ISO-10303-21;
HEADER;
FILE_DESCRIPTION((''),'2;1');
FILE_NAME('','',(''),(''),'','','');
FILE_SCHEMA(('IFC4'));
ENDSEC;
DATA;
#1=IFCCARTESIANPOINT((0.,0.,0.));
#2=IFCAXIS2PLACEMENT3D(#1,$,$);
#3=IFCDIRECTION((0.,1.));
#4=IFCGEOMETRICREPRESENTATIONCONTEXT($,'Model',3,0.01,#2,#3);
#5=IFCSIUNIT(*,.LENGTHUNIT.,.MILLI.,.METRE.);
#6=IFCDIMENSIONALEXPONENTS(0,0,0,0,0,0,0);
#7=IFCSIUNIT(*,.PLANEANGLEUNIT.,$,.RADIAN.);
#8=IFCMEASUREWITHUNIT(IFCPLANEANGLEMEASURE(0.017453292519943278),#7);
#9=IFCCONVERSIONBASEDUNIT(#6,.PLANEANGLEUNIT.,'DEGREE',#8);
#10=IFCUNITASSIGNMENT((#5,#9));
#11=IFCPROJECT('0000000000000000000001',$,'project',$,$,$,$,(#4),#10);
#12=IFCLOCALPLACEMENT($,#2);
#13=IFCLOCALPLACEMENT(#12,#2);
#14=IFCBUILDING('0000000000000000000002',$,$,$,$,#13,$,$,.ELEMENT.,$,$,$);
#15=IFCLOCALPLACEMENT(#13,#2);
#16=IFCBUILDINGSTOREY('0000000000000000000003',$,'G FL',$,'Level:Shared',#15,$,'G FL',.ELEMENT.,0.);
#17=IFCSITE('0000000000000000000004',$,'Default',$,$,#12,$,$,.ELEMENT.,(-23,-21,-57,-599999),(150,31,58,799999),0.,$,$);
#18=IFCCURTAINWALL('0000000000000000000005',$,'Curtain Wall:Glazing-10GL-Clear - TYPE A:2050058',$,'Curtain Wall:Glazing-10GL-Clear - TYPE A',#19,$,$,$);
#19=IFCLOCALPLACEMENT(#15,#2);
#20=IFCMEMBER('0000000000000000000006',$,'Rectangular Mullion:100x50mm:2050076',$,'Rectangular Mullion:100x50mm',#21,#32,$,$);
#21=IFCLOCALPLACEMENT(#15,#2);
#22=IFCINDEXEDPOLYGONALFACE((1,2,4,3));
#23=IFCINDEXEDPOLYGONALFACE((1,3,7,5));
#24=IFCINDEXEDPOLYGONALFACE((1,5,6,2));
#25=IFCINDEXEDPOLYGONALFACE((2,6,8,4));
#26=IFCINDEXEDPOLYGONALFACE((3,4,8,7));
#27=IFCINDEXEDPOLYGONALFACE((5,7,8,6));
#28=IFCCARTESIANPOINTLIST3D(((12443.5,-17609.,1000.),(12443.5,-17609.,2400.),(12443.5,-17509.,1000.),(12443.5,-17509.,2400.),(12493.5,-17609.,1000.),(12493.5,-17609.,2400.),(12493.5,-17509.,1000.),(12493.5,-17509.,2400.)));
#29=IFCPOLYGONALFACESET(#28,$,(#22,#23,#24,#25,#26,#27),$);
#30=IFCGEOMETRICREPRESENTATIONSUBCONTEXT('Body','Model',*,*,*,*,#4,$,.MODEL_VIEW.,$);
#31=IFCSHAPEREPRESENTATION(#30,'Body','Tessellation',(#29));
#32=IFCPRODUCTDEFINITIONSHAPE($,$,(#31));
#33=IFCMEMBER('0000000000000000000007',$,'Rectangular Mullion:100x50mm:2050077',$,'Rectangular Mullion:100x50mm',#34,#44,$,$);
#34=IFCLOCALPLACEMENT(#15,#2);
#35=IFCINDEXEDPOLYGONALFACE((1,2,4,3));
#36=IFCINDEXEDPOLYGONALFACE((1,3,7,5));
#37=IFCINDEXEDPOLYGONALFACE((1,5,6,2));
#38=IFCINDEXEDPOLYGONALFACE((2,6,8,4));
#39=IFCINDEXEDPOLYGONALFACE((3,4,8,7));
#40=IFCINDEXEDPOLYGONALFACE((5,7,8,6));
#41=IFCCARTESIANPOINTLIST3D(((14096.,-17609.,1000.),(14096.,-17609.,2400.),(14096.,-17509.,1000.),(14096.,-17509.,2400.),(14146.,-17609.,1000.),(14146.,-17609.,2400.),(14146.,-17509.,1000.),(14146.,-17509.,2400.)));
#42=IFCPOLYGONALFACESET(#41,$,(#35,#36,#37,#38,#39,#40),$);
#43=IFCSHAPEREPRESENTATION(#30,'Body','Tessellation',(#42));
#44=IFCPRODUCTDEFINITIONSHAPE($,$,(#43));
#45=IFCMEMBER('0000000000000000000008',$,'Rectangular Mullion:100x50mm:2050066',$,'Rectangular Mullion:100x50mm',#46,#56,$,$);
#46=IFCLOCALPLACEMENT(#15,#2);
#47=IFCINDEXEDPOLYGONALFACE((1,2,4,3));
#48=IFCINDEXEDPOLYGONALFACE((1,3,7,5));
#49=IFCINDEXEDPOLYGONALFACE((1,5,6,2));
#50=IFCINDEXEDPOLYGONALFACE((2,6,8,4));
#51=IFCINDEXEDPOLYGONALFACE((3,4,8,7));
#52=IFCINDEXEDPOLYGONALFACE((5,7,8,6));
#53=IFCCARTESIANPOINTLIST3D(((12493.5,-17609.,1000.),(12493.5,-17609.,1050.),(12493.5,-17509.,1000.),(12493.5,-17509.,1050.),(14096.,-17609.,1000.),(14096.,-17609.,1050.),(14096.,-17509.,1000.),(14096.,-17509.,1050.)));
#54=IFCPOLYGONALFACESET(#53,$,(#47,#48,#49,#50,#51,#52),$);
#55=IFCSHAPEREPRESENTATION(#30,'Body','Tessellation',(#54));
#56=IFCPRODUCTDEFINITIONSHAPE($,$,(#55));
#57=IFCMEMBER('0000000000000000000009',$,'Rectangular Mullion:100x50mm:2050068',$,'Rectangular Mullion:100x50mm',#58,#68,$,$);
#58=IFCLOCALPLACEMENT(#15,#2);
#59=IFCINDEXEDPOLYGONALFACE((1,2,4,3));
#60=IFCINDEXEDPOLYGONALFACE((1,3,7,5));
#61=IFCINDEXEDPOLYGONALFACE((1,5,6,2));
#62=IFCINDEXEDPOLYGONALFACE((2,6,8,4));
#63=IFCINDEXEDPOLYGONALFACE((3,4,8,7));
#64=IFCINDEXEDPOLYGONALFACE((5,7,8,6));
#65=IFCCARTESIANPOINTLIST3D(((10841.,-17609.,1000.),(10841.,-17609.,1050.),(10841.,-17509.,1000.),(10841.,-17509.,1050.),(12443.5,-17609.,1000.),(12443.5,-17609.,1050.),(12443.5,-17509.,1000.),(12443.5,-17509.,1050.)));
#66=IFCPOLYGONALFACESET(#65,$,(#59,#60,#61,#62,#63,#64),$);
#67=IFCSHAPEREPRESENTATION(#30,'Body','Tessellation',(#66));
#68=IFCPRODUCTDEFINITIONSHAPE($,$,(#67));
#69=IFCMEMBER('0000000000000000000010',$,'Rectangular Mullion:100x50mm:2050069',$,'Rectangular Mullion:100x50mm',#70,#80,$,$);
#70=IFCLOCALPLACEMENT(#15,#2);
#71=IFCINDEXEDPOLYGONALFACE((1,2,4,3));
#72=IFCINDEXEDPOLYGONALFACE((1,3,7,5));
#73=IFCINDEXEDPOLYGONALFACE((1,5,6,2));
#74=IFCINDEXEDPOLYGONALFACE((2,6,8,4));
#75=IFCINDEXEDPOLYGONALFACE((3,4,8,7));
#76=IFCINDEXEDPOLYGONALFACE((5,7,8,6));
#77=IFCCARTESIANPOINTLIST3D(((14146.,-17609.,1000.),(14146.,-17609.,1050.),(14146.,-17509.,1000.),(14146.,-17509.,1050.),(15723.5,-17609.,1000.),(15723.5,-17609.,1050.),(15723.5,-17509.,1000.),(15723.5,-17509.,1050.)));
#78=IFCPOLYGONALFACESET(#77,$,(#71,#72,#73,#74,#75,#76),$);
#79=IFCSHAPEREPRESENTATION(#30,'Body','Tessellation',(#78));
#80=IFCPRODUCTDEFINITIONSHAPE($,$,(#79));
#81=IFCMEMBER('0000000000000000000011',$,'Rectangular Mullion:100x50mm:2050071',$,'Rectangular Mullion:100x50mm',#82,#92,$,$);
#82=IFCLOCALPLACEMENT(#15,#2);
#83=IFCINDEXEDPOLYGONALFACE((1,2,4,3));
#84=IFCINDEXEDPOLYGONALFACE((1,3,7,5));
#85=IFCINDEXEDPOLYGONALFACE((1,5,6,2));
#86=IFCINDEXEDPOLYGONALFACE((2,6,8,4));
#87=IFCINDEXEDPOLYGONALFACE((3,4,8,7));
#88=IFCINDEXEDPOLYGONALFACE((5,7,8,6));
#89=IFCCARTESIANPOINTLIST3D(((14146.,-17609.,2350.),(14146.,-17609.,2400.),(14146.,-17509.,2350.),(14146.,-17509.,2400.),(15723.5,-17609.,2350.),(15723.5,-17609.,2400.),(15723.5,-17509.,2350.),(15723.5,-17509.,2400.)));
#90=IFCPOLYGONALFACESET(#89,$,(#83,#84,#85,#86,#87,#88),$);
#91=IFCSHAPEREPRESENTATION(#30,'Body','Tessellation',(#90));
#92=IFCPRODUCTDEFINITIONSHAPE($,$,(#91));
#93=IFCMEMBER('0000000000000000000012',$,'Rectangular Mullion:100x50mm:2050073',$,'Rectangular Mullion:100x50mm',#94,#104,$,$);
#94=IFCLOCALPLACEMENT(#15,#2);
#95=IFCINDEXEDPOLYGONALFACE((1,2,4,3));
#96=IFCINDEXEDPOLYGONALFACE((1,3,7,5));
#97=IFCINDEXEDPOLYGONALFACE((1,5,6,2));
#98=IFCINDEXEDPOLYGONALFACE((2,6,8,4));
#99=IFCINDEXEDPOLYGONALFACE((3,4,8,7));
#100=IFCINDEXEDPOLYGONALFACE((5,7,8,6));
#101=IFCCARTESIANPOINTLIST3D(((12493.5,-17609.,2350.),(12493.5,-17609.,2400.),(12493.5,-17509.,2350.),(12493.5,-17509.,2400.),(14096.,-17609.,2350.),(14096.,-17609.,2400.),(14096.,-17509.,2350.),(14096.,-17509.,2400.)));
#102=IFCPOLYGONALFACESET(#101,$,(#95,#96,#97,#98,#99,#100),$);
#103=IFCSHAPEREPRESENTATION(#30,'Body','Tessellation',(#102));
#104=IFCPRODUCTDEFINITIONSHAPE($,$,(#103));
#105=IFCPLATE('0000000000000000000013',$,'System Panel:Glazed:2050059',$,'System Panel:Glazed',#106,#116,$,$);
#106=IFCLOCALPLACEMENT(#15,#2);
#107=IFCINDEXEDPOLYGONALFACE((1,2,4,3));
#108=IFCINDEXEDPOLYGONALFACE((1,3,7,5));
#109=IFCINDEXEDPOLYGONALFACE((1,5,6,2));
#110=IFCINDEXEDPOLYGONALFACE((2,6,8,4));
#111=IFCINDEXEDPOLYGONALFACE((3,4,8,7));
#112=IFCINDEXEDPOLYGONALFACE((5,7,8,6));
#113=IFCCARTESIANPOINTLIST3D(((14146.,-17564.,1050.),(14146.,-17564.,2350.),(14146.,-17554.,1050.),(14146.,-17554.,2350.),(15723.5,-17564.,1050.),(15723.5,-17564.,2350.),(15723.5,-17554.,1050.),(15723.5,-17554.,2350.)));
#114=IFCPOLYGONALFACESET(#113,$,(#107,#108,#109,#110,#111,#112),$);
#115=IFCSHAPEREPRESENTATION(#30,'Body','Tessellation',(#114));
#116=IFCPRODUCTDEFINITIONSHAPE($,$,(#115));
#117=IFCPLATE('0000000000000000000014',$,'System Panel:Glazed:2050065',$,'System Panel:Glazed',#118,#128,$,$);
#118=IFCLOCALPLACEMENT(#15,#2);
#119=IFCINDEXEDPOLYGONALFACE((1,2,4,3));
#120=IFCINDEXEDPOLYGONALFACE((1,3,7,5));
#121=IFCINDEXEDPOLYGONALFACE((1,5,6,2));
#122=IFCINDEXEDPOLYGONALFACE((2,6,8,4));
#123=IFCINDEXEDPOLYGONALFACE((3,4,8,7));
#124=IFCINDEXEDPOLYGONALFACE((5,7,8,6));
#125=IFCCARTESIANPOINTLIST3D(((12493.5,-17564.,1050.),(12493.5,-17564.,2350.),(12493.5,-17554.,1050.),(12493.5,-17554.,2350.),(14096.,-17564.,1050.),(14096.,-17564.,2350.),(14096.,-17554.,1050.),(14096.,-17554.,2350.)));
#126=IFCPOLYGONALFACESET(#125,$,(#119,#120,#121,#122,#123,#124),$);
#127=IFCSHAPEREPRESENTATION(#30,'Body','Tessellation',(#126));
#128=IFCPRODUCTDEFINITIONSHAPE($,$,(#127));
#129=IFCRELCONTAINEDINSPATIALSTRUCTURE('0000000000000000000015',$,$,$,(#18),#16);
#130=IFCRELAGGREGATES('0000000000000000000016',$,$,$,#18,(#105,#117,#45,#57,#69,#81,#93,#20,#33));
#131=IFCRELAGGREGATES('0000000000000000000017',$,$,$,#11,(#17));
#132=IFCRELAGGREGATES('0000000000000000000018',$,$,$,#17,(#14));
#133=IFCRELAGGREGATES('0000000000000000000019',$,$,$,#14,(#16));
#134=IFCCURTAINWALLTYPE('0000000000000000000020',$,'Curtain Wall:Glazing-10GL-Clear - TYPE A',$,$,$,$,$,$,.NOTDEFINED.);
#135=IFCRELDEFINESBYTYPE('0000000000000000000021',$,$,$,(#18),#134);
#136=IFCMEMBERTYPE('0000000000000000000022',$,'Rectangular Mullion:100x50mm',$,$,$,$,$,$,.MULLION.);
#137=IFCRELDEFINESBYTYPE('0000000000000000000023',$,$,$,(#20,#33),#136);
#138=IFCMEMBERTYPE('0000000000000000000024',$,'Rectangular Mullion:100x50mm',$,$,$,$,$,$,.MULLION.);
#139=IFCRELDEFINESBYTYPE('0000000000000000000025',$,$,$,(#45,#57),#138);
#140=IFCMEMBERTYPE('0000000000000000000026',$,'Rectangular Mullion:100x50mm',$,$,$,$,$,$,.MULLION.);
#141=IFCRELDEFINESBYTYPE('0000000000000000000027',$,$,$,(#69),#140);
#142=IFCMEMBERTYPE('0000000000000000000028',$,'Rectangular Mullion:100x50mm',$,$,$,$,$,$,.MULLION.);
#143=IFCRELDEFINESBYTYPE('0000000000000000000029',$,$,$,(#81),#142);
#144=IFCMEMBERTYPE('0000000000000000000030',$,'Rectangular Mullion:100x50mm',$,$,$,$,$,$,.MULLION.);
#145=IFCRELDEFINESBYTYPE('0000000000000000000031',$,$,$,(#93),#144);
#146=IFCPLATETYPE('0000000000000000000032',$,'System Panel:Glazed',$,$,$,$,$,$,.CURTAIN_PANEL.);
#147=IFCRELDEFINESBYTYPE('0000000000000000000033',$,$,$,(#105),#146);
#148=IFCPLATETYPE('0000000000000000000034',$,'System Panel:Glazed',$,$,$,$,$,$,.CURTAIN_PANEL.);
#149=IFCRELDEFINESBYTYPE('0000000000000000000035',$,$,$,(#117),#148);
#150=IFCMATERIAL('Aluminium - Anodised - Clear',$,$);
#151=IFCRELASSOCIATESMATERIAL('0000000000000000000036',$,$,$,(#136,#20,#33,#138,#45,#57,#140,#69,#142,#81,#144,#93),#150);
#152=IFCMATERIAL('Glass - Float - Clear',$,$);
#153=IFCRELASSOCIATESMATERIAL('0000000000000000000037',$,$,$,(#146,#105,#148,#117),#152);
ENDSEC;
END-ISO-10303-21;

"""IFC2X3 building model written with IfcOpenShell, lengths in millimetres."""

from ifc_helpers import new_model, entity, si_unit, converted_unit, direction, frame, frame_2d, origin, origin_2d_with_axis, place, context, subcontext, project, spatial, rectangle, extrude, source, transform, mapped, material, type_object, type_shapes, element, aggregate, save


model = new_model("IFC2X3")

# Units and contexts
model_context = context("Model", 3, precision=0.01, world=origin(), true_north=direction((0.0, 1.0)))
body_context = subcontext(model_context, "Body", "Model", "MODEL_VIEW")
ifc_project = project(units=[si_unit("LENGTHUNIT", "METRE", prefix="MILLI"), converted_unit("PLANEANGLEUNIT", "DEGREE", entity("IfcPlaneAngleMeasure", 0.017453292519943278), si_unit("PLANEANGLEUNIT", "RADIAN"), dimensions=[0, 0, 0, 0, 0, 0, 0])], contexts=[model_context])

# Site, building, storey
site_placement = place(None, origin())
site = spatial("IfcSite", under=ifc_project, at=site_placement, Name="Default", CompositionType="ELEMENT", RefLatitude=(-23, -21, -57, -599999), RefLongitude=(150, 31, 58, 799999), RefElevation=0.0)
building_placement = place(site_placement, origin())
building = spatial("IfcBuilding", under=site, at=building_placement, CompositionType="ELEMENT")
storey_placement = place(building_placement, origin())
storey = spatial("IfcBuildingStorey", under=building, at=storey_placement, Name="G FL", ObjectType="Level:Shared", LongName="G FL", CompositionType="ELEMENT", Elevation=0.0)

# Curtain wall, members, plates
curtain_wall_type = type_object("IfcCurtainWallType", Name="Curtain Wall:Glazing-10GL-Clear - TYPE A", PredefinedType="NOTDEFINED")
curtain_wall_placement = place(storey_placement, origin())
curtain_wall = element("IfcCurtainWall", 1, at=curtain_wall_placement, inside=storey, type_object=curtain_wall_type, Name="Curtain Wall:Glazing-10GL-Clear - TYPE A:2050058", ObjectType="Curtain Wall:Glazing-10GL-Clear - TYPE A")
ifc_material_1 = material(Name="Aluminium - Anodised - Clear")
member_type_1 = type_object("IfcMemberType", Name="Rectangular Mullion:100x50mm", PredefinedType="MULLION", material=ifc_material_1)
shared_shape_1 = source(origin(), body_context, "Body", "SweptSolid", [
    extrude(rectangle(XDim=50.0, YDim=100.0, at=frame_2d((0.0, 0.0), x_axis=(1.0, 0.0))), frame((0.0, 0.0, -1400.0), z_axis=(0.0, 0.0, 1.0), x_axis=(-1.0, 0.0, 0.0)), (0.0, 0.0, 1.0), 1400.0),
])
type_shapes(member_type_1, [shared_shape_1])
member_1_placement = place(curtain_wall_placement, frame((12468.5, -17559.0, 1000.0), z_axis=(0.0, 0.0, -1.0), x_axis=(-1.0, 0.0, 0.0)))
member_1 = element("IfcMember", 2, at=member_1_placement, type_object=member_type_1, material=ifc_material_1, Name="Rectangular Mullion:100x50mm:2050076", ObjectType="Rectangular Mullion:100x50mm", context=body_context, shape_type="MappedRepresentation", body=[
    mapped(shared_shape_1, transform((0.0, 0.0, 0.0), scale=1.0)),
])
member_2_placement = place(curtain_wall_placement, frame((14121.0, -17559.0, 1000.0), z_axis=(0.0, 0.0, -1.0), x_axis=(-1.0, 0.0, 0.0)))
member_2 = element("IfcMember", 3, at=member_2_placement, type_object=member_type_1, material=ifc_material_1, Name="Rectangular Mullion:100x50mm:2050077", ObjectType="Rectangular Mullion:100x50mm", context=body_context, shape_type="MappedRepresentation", body=[
    mapped(shared_shape_1, transform((0.0, 0.0, 0.0), scale=1.0)),
])
member_type_2 = type_object("IfcMemberType", Name="Rectangular Mullion:100x50mm", PredefinedType="MULLION", material=ifc_material_1)
shared_shape_2 = source(origin(), body_context, "Body", "SweptSolid", [
    extrude(rectangle(XDim=50.0, YDim=100.0, at=frame_2d((0.0, 0.0), x_axis=(1.0, 0.0))), frame((-25.0, 0.0, -1602.5), z_axis=(0.0, 0.0, 1.0), x_axis=(-1.0, 0.0, 0.0)), (0.0, 0.0, 1.0), 1602.5),
])
type_shapes(member_type_2, [shared_shape_2])
member_3_placement = place(curtain_wall_placement, frame((14096.0, -17559.0, 1000.0), z_axis=(1.0, 0.0, 0.0), x_axis=(0.0, 0.0, -1.0)))
member_3 = element("IfcMember", 4, at=member_3_placement, type_object=member_type_2, material=ifc_material_1, Name="Rectangular Mullion:100x50mm:2050066", ObjectType="Rectangular Mullion:100x50mm", context=body_context, shape_type="MappedRepresentation", body=[
    mapped(shared_shape_2, transform((0.0, 0.0, 0.0), scale=1.0)),
])
member_4_placement = place(curtain_wall_placement, frame((12443.5, -17559.0, 1000.0), z_axis=(1.0, 0.0, 0.0), x_axis=(0.0, 0.0, -1.0)))
member_4 = element("IfcMember", 5, at=member_4_placement, type_object=member_type_2, material=ifc_material_1, Name="Rectangular Mullion:100x50mm:2050068", ObjectType="Rectangular Mullion:100x50mm", context=body_context, shape_type="MappedRepresentation", body=[
    mapped(shared_shape_2, transform((0.0, 0.0, 0.0), scale=1.0)),
])
member_type_3 = type_object("IfcMemberType", Name="Rectangular Mullion:100x50mm", PredefinedType="MULLION", material=ifc_material_1)
shared_shape_3 = source(origin(), body_context, "Body", "SweptSolid", [
    extrude(rectangle(XDim=50.0, YDim=100.0, at=frame_2d((0.0, 0.0), x_axis=(1.0, 0.0))), frame((-25.0, 0.0, -1577.5), z_axis=(0.0, 0.0, 1.0), x_axis=(-1.0, 0.0, 0.0)), (0.0, 0.0, 1.0), 1577.5),
])
type_shapes(member_type_3, [shared_shape_3])
member_5_placement = place(curtain_wall_placement, frame((15723.5, -17559.0, 1000.0), z_axis=(1.0, 0.0, 0.0), x_axis=(0.0, 0.0, -1.0)))
member_5 = element("IfcMember", 6, at=member_5_placement, type_object=member_type_3, material=ifc_material_1, Name="Rectangular Mullion:100x50mm:2050069", ObjectType="Rectangular Mullion:100x50mm", context=body_context, shape_type="MappedRepresentation", body=[
    mapped(shared_shape_3, transform((0.0, 0.0, 0.0), scale=1.0)),
])
member_type_4 = type_object("IfcMemberType", Name="Rectangular Mullion:100x50mm", PredefinedType="MULLION", material=ifc_material_1)
shared_shape_4 = source(origin(), body_context, "Body", "SweptSolid", [
    extrude(rectangle(XDim=50.0, YDim=100.0, at=origin_2d_with_axis()), frame((-25.0, 0.0, -1577.5), z_axis=(0.0, 0.0, 1.0), x_axis=(-1.0, 0.0, 0.0)), (0.0, 0.0, 1.0), 1577.5),
])
type_shapes(member_type_4, [shared_shape_4])
member_6_placement = place(curtain_wall_placement, frame((14146.0, -17559.0, 2400.0), z_axis=(-1.0, 0.0, 0.0), x_axis=(0.0, 0.0, 1.0)))
member_6 = element("IfcMember", 7, at=member_6_placement, type_object=member_type_4, material=ifc_material_1, Name="Rectangular Mullion:100x50mm:2050071", ObjectType="Rectangular Mullion:100x50mm", context=body_context, shape_type="MappedRepresentation", body=[
    mapped(shared_shape_4, transform((0.0, 0.0, 0.0), scale=1.0)),
])
member_type_5 = type_object("IfcMemberType", Name="Rectangular Mullion:100x50mm", PredefinedType="MULLION", material=ifc_material_1)
shared_shape_5 = source(origin(), body_context, "Body", "SweptSolid", [
    extrude(rectangle(XDim=50.0, YDim=100.0, at=origin_2d_with_axis()), frame((-25.0, 0.0, -1602.5), z_axis=(0.0, 0.0, 1.0), x_axis=(-1.0, 0.0, 0.0)), (0.0, 0.0, 1.0), 1602.5),
])
type_shapes(member_type_5, [shared_shape_5])
member_7_placement = place(curtain_wall_placement, frame((12493.5, -17559.0, 2400.0), z_axis=(-1.0, 0.0, 0.0), x_axis=(0.0, 0.0, 1.0)))
member_7 = element("IfcMember", 8, at=member_7_placement, type_object=member_type_5, material=ifc_material_1, Name="Rectangular Mullion:100x50mm:2050073", ObjectType="Rectangular Mullion:100x50mm", context=body_context, shape_type="MappedRepresentation", body=[
    mapped(shared_shape_5, transform((0.0, 0.0, 0.0), scale=1.0)),
])
ifc_material_2 = material(Name="Glass - Float - Clear")
plate_type_1 = type_object("IfcPlateType", Name="System Panel:Glazed", PredefinedType="CURTAIN_PANEL", material=ifc_material_2)
shared_shape_6 = source(origin(), body_context, "Body", "SweptSolid", [
    extrude(rectangle(XDim=10.0, YDim=1577.5, at=origin_2d_with_axis()), frame((0.0, 0.0, 0.0), z_axis=(0.0, 0.0, 1.0), x_axis=(0.0, 1.0, 0.0)), (0.0, 0.0, 1.0), 1300.0),
])
type_shapes(plate_type_1, [shared_shape_6])
plate_1_placement = place(curtain_wall_placement, frame((14934.8, -17559.0, 1050.0), z_axis=(0.0, 0.0, 1.0), x_axis=(-1.0, 0.0, 0.0)))
plate_1 = element("IfcPlate", 9, at=plate_1_placement, type_object=plate_type_1, material=ifc_material_2, Name="System Panel:Glazed:2050059", ObjectType="System Panel:Glazed", context=body_context, shape_type="MappedRepresentation", body=[
    mapped(shared_shape_6, transform((0.0, 0.0, 0.0), scale=1.0)),
])
plate_type_2 = type_object("IfcPlateType", Name="System Panel:Glazed", PredefinedType="CURTAIN_PANEL", material=ifc_material_2)
shared_shape_7 = source(origin(), body_context, "Body", "SweptSolid", [
    extrude(rectangle(XDim=10.0, YDim=1602.5, at=origin_2d_with_axis()), frame((0.0, 0.0, 0.0), z_axis=(0.0, 0.0, 1.0), x_axis=(0.0, 1.0, 0.0)), (0.0, 0.0, 1.0), 1300.0),
])
type_shapes(plate_type_2, [shared_shape_7])
plate_2_placement = place(curtain_wall_placement, frame((13294.8, -17559.0, 1050.0), z_axis=(0.0, 0.0, 1.0), x_axis=(-1.0, 0.0, 0.0)))
plate_2 = element("IfcPlate", 10, at=plate_2_placement, type_object=plate_type_2, material=ifc_material_2, Name="System Panel:Glazed:2050065", ObjectType="System Panel:Glazed", context=body_context, shape_type="MappedRepresentation", body=[
    mapped(shared_shape_7, transform((0.0, 0.0, 0.0), scale=1.0)),
])
aggregate(curtain_wall, [plate_1, plate_2, member_3, member_4, member_5, member_6, member_7, member_1, member_2])

save(model, "model.ifc")
